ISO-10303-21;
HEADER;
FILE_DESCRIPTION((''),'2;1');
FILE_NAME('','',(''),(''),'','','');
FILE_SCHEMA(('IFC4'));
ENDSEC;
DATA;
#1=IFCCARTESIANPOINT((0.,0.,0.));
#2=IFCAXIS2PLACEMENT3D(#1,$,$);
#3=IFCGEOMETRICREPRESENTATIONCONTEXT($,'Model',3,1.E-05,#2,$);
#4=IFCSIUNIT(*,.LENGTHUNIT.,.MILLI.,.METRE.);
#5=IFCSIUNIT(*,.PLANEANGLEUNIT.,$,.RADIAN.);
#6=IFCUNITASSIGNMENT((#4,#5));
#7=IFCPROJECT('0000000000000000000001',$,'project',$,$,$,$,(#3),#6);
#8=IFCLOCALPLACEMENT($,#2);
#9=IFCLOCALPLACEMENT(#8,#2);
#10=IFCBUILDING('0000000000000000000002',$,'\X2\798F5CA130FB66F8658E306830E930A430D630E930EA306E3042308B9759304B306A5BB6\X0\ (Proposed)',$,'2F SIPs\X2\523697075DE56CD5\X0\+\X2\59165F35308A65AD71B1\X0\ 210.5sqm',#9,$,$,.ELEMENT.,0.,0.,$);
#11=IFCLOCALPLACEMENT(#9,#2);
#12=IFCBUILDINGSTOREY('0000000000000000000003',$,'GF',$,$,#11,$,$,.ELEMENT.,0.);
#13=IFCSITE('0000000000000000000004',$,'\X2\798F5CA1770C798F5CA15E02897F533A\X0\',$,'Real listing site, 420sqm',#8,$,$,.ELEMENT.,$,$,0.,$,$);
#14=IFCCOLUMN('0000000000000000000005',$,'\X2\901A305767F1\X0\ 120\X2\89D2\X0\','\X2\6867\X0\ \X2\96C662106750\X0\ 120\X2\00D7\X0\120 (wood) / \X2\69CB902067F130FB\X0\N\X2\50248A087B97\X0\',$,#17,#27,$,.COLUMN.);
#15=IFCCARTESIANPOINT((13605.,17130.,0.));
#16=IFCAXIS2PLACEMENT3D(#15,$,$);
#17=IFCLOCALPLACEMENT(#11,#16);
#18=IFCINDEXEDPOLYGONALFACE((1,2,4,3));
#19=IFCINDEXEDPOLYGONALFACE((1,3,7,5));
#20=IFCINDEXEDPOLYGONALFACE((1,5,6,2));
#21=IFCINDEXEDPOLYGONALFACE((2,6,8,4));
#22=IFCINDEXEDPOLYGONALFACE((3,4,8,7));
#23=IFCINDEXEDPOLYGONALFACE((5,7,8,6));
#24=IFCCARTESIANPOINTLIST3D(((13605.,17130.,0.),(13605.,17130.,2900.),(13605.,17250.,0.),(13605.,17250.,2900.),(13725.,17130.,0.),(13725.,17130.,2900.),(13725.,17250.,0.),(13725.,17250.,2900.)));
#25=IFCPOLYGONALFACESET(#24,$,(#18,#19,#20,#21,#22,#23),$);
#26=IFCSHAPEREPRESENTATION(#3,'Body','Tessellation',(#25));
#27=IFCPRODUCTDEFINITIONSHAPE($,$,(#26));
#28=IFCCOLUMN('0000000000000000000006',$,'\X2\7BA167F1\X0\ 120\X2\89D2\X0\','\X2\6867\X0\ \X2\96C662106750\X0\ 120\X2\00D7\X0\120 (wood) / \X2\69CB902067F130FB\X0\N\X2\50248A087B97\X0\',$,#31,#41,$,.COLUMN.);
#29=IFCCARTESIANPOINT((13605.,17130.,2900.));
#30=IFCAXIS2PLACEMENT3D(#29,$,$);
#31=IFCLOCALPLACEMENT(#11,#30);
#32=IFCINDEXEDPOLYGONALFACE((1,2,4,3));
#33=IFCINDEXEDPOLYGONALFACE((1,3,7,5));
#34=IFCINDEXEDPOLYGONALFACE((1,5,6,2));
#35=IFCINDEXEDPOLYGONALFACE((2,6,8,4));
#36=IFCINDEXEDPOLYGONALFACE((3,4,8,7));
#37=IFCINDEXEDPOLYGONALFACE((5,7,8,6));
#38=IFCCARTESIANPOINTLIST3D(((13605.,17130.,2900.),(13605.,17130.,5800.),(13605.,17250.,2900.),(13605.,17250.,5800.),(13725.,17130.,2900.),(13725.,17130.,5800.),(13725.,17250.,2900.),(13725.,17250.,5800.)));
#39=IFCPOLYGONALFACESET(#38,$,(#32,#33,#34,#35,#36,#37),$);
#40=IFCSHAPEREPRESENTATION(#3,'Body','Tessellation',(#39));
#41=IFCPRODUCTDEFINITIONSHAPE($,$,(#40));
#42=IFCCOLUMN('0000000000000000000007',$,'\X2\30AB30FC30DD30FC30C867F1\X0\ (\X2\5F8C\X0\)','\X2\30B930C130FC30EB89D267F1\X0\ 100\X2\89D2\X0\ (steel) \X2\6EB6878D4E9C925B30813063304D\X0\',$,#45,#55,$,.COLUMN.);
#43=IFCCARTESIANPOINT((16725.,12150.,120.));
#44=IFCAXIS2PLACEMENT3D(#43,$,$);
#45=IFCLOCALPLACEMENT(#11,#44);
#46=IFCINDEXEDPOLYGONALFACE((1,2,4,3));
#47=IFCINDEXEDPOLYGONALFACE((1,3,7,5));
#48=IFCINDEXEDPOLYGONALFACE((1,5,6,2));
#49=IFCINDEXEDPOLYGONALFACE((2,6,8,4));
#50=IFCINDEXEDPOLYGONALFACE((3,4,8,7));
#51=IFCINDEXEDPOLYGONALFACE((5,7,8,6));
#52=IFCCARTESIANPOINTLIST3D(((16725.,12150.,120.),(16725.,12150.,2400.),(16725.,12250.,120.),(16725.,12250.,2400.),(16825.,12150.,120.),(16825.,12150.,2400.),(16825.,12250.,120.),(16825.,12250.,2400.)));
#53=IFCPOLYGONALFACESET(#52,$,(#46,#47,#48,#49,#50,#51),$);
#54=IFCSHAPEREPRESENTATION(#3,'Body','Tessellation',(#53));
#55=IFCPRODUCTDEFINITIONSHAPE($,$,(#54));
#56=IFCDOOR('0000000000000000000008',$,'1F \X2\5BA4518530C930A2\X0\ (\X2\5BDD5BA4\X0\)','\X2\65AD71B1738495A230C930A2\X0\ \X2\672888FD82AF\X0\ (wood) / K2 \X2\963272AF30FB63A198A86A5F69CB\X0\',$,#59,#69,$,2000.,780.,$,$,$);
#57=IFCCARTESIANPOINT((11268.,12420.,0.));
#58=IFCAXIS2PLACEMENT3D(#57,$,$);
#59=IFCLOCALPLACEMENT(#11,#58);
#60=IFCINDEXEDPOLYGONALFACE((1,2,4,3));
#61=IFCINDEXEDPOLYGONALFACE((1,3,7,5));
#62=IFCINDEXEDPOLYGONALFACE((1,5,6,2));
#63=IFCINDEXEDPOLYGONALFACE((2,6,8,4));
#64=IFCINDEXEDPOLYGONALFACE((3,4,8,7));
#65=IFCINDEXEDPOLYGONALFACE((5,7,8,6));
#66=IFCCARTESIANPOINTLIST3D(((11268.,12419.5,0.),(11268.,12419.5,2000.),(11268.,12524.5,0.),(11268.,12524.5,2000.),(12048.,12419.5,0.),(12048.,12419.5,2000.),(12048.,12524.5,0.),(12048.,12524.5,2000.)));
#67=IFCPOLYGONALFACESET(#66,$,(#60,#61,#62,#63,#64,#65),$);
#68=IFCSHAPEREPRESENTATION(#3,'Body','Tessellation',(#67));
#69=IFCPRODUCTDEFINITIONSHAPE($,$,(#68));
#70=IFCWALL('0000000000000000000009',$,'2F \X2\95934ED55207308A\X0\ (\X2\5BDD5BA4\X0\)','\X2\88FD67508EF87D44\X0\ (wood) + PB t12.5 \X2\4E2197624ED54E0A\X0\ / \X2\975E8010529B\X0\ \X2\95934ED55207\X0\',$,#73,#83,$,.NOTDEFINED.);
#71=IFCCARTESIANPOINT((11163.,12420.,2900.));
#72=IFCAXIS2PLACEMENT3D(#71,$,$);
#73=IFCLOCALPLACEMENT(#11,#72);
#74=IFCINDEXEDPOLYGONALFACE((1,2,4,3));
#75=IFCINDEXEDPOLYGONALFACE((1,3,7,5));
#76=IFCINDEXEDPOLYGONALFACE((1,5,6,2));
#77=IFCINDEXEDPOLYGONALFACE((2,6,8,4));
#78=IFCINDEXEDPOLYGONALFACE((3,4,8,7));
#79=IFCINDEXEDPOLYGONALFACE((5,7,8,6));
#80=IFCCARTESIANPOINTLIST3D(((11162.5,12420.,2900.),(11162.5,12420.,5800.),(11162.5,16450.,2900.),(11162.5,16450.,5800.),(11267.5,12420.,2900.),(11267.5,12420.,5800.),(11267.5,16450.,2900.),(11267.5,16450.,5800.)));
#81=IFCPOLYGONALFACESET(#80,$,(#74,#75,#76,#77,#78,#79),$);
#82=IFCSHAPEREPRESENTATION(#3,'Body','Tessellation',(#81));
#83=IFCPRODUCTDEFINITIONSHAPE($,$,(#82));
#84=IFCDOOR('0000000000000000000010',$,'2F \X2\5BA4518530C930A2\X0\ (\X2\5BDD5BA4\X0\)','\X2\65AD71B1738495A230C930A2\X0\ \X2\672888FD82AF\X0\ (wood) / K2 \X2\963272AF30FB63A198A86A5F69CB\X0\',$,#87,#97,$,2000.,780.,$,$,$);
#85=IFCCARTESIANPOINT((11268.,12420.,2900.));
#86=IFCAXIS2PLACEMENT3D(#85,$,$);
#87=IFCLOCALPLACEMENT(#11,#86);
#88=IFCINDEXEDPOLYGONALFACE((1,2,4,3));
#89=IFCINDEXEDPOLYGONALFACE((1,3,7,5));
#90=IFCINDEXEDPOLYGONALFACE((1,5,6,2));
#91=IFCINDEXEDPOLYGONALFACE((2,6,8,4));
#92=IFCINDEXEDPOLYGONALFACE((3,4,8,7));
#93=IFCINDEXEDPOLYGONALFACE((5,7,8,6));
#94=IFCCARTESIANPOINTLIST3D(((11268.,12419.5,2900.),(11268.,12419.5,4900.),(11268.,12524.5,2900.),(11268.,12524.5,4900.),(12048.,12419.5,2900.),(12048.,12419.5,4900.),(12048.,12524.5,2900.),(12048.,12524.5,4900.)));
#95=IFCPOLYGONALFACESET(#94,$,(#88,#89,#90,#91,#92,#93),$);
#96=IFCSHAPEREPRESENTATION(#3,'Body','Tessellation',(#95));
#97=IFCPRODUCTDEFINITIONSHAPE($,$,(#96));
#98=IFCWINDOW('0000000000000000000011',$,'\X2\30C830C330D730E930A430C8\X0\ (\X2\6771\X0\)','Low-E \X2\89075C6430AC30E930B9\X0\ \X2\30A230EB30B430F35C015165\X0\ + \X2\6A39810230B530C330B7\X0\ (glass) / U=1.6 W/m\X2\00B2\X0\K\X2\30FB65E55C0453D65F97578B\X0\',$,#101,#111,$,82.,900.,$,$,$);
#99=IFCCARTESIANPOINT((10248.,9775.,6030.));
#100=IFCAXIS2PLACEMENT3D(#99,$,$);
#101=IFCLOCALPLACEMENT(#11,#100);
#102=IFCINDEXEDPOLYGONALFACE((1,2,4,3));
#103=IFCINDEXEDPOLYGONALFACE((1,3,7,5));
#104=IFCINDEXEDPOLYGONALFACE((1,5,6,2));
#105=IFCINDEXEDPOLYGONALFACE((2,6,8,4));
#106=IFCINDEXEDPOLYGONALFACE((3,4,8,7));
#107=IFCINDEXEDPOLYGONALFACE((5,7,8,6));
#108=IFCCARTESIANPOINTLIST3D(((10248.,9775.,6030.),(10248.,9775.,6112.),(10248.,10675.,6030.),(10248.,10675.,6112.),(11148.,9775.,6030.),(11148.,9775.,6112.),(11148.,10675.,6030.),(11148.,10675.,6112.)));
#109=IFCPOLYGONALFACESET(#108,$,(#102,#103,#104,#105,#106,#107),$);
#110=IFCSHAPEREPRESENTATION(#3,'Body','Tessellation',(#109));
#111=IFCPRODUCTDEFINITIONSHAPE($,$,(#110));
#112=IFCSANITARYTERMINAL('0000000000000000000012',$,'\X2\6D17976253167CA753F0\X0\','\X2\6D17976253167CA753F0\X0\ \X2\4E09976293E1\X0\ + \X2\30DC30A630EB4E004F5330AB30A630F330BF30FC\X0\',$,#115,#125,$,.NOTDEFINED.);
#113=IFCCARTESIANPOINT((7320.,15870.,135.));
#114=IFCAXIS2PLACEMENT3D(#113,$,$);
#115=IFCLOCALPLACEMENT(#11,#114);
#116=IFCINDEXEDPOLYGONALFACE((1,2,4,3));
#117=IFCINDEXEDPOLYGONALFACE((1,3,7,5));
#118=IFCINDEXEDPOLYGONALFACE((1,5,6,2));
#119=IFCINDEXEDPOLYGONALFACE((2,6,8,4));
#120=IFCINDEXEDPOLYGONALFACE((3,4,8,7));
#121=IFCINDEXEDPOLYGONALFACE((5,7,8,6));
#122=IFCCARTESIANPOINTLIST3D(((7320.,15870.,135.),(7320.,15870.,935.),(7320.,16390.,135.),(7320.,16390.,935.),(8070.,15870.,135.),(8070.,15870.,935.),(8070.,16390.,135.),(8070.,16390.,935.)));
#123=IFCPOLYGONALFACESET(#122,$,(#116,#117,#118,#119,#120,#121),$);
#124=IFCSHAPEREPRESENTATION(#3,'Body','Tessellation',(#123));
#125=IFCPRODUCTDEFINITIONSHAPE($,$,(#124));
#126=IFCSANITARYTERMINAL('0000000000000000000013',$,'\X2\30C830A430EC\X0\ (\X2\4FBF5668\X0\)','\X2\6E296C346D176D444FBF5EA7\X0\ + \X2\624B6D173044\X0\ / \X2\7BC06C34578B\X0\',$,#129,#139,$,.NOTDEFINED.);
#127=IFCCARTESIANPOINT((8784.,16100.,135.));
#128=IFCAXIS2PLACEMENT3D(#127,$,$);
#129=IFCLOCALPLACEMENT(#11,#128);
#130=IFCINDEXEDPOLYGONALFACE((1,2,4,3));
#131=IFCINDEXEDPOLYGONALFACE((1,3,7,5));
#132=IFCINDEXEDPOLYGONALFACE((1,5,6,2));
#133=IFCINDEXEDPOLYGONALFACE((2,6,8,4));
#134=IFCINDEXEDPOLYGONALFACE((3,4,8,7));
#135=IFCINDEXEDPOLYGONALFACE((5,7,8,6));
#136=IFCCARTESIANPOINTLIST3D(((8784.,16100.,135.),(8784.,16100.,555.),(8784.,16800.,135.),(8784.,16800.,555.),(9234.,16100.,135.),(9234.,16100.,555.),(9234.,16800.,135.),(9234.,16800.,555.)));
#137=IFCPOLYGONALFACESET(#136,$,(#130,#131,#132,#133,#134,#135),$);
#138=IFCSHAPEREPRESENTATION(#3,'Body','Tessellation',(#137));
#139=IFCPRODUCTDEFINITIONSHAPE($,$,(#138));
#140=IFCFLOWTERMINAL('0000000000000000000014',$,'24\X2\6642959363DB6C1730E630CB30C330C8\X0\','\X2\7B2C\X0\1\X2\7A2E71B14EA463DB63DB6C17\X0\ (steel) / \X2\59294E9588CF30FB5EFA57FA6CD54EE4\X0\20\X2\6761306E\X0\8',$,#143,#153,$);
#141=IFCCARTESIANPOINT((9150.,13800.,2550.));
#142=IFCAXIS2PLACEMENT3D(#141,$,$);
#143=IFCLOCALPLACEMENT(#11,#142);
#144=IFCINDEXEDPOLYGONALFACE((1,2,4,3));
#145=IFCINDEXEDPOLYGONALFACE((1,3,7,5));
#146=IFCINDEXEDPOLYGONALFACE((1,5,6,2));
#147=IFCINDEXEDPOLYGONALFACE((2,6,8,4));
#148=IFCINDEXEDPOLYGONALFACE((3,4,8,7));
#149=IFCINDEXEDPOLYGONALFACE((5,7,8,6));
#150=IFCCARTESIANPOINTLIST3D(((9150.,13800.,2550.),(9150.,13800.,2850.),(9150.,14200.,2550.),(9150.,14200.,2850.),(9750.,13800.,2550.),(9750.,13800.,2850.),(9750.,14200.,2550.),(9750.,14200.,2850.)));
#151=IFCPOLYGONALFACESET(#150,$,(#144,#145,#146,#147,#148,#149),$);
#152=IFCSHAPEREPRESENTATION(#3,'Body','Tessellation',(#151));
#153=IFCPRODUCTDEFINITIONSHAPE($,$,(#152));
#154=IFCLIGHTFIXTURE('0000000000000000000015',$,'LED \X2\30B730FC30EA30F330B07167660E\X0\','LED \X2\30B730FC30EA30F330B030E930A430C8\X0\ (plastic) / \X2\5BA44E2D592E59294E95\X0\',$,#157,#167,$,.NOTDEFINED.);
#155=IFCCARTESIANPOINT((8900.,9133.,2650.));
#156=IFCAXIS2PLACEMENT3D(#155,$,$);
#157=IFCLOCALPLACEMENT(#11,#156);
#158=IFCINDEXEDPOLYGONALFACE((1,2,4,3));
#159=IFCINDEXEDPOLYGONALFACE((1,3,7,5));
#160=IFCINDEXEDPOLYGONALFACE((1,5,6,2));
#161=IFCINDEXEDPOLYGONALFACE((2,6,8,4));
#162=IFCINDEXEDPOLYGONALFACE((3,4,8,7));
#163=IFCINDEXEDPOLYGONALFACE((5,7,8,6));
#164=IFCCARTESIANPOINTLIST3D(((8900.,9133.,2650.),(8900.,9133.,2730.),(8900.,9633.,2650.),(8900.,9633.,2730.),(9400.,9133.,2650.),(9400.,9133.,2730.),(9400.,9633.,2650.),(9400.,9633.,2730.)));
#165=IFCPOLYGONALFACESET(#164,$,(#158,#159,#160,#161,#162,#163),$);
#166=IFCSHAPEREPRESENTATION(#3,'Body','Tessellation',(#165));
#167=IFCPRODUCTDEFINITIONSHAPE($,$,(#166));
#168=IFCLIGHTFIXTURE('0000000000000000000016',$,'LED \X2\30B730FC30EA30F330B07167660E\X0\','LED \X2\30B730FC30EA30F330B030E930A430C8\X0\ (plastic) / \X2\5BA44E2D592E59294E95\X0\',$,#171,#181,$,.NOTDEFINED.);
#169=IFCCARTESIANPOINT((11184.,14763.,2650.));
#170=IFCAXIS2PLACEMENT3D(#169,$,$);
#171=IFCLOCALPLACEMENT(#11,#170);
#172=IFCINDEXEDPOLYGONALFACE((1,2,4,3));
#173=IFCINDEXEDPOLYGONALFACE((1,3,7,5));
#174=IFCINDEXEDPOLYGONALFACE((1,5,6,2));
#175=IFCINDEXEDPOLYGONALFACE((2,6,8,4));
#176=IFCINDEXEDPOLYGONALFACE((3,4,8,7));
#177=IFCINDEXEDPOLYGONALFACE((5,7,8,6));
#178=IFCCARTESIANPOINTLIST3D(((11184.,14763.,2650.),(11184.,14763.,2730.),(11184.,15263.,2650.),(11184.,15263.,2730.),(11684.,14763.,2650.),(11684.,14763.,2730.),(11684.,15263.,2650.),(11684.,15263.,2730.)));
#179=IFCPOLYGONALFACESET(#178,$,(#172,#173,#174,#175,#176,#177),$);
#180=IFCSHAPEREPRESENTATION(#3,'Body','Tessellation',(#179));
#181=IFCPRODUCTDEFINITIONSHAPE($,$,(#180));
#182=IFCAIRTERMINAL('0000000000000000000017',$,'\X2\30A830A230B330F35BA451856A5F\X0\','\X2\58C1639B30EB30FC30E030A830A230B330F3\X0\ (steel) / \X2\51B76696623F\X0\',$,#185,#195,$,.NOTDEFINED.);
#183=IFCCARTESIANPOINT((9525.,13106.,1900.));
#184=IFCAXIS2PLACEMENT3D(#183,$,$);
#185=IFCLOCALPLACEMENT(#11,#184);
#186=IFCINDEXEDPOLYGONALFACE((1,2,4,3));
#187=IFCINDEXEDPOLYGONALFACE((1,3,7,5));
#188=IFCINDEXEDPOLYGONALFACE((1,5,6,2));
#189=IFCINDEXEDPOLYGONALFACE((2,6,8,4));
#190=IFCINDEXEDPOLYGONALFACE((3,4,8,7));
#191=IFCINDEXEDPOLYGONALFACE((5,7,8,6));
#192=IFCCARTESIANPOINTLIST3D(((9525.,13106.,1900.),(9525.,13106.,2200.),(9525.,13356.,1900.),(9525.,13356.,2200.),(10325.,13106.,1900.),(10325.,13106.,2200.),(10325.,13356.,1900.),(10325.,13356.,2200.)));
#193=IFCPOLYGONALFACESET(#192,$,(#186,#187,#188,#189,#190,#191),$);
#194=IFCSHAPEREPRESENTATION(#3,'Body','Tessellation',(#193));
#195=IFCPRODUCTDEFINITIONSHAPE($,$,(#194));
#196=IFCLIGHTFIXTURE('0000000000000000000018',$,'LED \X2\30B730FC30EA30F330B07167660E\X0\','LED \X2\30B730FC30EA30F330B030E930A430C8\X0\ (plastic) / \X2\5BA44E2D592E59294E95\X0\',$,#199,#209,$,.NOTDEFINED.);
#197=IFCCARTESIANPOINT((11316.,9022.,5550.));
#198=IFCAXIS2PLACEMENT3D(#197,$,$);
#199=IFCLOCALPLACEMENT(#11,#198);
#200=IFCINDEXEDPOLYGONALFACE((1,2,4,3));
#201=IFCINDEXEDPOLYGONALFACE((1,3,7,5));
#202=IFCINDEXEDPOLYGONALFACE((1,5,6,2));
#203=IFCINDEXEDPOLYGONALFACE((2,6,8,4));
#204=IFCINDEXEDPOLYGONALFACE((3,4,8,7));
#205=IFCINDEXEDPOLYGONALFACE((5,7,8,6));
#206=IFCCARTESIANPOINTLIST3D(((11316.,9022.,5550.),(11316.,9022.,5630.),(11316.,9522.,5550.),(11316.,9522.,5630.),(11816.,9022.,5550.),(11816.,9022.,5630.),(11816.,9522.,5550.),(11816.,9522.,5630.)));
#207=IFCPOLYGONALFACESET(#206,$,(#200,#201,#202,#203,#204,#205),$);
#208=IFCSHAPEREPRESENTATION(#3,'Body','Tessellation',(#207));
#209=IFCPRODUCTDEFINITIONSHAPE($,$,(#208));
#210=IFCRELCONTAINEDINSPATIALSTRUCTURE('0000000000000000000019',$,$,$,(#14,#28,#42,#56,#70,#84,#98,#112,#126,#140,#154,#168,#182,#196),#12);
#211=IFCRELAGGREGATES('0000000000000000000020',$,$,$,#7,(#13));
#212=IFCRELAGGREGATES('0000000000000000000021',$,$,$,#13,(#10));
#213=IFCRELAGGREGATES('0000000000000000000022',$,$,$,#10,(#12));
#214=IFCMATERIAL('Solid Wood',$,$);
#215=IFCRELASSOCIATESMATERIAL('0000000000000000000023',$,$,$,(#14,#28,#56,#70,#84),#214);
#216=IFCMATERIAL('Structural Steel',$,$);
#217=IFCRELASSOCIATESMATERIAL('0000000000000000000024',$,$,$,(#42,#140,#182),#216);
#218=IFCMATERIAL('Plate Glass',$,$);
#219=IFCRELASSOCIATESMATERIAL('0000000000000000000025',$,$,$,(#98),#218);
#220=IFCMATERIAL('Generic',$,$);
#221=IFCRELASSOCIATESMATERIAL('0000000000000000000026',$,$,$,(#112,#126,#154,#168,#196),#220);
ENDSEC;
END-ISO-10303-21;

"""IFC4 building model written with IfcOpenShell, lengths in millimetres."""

from ifc_helpers import new_model, si_unit, frame, frame_2d, origin, place, context, project, spatial, rectangle, extrude, material, element, save


model = new_model("IFC4")

# Units and contexts
model_context = context("Model", 3, precision=1e-05, world=origin())
ifc_project = project(units=[si_unit("LENGTHUNIT", "METRE", prefix="MILLI"), si_unit("PLANEANGLEUNIT", "RADIAN")], contexts=[model_context])

# Site, building, storey
site_placement = place(None, origin())
site = spatial("IfcSite", under=ifc_project, at=site_placement, Name="福岡県福岡市西区", ObjectType="Real listing site, 420sqm", CompositionType="ELEMENT", RefElevation=0.0)
building_placement = place(site_placement, origin())
building = spatial("IfcBuilding", under=site, at=building_placement, Name="福岡・書斎とライブラリのある静かな家 (Proposed)", ObjectType="2F SIPs制震工法+外張り断熱 210.5sqm", CompositionType="ELEMENT", ElevationOfRefHeight=0.0, ElevationOfTerrain=0.0)
storey_placement = place(building_placement, origin())
storey = spatial("IfcBuildingStorey", under=building, at=storey_placement, Name="GF", CompositionType="ELEMENT", Elevation=0.0)

# Columns
ifc_material_1 = material(Name="Solid Wood")
column_1_placement = place(storey_placement, frame((13605.0, 17130.0, 0.0)))
element("IfcColumn", 1, at=column_1_placement, inside=storey, material=ifc_material_1, Name="通し柱 120角", Description="桧 集成材 120×120 (wood) / 構造柱・N値計算", PredefinedType="COLUMN", context=model_context, shape_type="SweptSolid", body=[
    extrude(rectangle(XDim=120.0, YDim=120.0, at=frame_2d((60.0, 60.0))), frame((13605.0, 17130.0, 0.0)), (0.0, 0.0, 1.0), 2900.0),
])
column_2_placement = place(storey_placement, frame((13605.0, 17130.0, 2900.0)))
element("IfcColumn", 2, at=column_2_placement, inside=storey, material=ifc_material_1, Name="管柱 120角", Description="桧 集成材 120×120 (wood) / 構造柱・N値計算", PredefinedType="COLUMN", context=model_context, shape_type="SweptSolid", body=[
    extrude(rectangle(XDim=120.0, YDim=120.0, at=frame_2d((60.0, 60.0))), frame((13605.0, 17130.0, 2900.0)), (0.0, 0.0, 1.0), 2900.0),
])
ifc_material_2 = material(Name="Structural Steel")
column_3_placement = place(storey_placement, frame((16725.0, 12150.0, 120.0)))
element("IfcColumn", 3, at=column_3_placement, inside=storey, material=ifc_material_2, Name="カーポート柱 (後)", Description="スチール角柱 100角 (steel) 溶融亜鉛めっき", PredefinedType="COLUMN", context=model_context, shape_type="SweptSolid", body=[
    extrude(rectangle(XDim=100.0, YDim=100.0, at=frame_2d((50.0, 50.0))), frame((16725.0, 12150.0, 120.0)), (0.0, 0.0, 1.0), 2280.0),
])

# Door
door_1_placement = place(storey_placement, frame((11268.0, 12420.0, 0.0)))
element("IfcDoor", 4, at=door_1_placement, inside=storey, material=ifc_material_1, Name="1F 室内ドア (寝室)", Description="断熱玄関ドア 木製芯 (wood) / K2 防犯・採風機構", OverallHeight=2000.0, OverallWidth=780.0, context=model_context, shape_type="SweptSolid", body=[
    extrude(rectangle(XDim=780.0, YDim=105.0, at=frame_2d((390.0, 52.0))), frame((11268.0, 12420.0, 0.0)), (0.0, 0.0, 1.0), 2000.0),
])

# Wall
wall_1_placement = place(storey_placement, frame((11163.0, 12420.0, 2900.0)))
element("IfcWall", 5, at=wall_1_placement, inside=storey, material=ifc_material_1, Name="2F 間仕切り (寝室)", Description="製材軸組 (wood) + PB t12.5 両面仕上 / 非耐力 間仕切", PredefinedType="NOTDEFINED", context=model_context, shape_type="SweptSolid", body=[
    extrude(rectangle(XDim=105.0, YDim=4030.0, at=frame_2d((52.0, 2015.0))), frame((11163.0, 12420.0, 2900.0)), (0.0, 0.0, 1.0), 2900.0),
])

# Door
door_2_placement = place(storey_placement, frame((11268.0, 12420.0, 2900.0)))
element("IfcDoor", 6, at=door_2_placement, inside=storey, material=ifc_material_1, Name="2F 室内ドア (寝室)", Description="断熱玄関ドア 木製芯 (wood) / K2 防犯・採風機構", OverallHeight=2000.0, OverallWidth=780.0, context=model_context, shape_type="SweptSolid", body=[
    extrude(rectangle(XDim=780.0, YDim=105.0, at=frame_2d((390.0, 52.0))), frame((11268.0, 12420.0, 2900.0)), (0.0, 0.0, 1.0), 2000.0),
])

# Window
ifc_material_3 = material(Name="Plate Glass")
window_placement = place(storey_placement, frame((10248.0, 9775.0, 6030.0)))
element("IfcWindow", 7, at=window_placement, inside=storey, material=ifc_material_3, Name="トップライト (東)", Description="Low-E 複層ガラス アルゴン封入 + 樹脂サッシ (glass) / U=1.6 W/m²K・日射取得型", OverallHeight=82.0, OverallWidth=900.0, context=model_context, shape_type="SweptSolid", body=[
    extrude(rectangle(XDim=900.0, YDim=900.0, at=frame_2d((450.0, 450.0))), frame((10248.0, 9775.0, 6030.0)), (0.0, 0.0, 1.0), 82.0),
])

# Sanitary terminals
ifc_material_4 = material(Name="Generic")
sanitary_terminal_1_placement = place(storey_placement, frame((7320.0, 15870.0, 135.0)))
element("IfcSanitaryTerminal", 8, at=sanitary_terminal_1_placement, inside=storey, material=ifc_material_4, Name="洗面化粧台", Description="洗面化粧台 三面鏡 + ボウル一体カウンター", PredefinedType="NOTDEFINED", context=model_context, shape_type="SweptSolid", body=[
    extrude(rectangle(XDim=750.0, YDim=520.0, at=frame_2d((375.0, 260.0))), frame((7320.0, 15870.0, 135.0)), (0.0, 0.0, 1.0), 800.0),
])
sanitary_terminal_2_placement = place(storey_placement, frame((8784.0, 16100.0, 135.0)))
element("IfcSanitaryTerminal", 9, at=sanitary_terminal_2_placement, inside=storey, material=ifc_material_4, Name="トイレ (便器)", Description="温水洗浄便座 + 手洗い / 節水型", PredefinedType="NOTDEFINED", context=model_context, shape_type="SweptSolid", body=[
    extrude(rectangle(XDim=450.0, YDim=700.0, at=frame_2d((225.0, 350.0))), frame((8784.0, 16100.0, 135.0)), (0.0, 0.0, 1.0), 420.0),
])

# Flow terminal
flow_terminal_placement = place(storey_placement, frame((9150.0, 13800.0, 2550.0)))
element("IfcFlowTerminal", 10, at=flow_terminal_placement, inside=storey, material=ifc_material_2, Name="24時間換気ユニット", Description="第1種熱交換換気 (steel) / 天井裏・建基法令20条の8", context=model_context, shape_type="SweptSolid", body=[
    extrude(rectangle(XDim=600.0, YDim=400.0, at=frame_2d((300.0, 200.0))), frame((9150.0, 13800.0, 2550.0)), (0.0, 0.0, 1.0), 300.0),
])

# Light fixtures
light_fixture_1_placement = place(storey_placement, frame((8900.0, 9133.0, 2650.0)))
element("IfcLightFixture", 11, at=light_fixture_1_placement, inside=storey, material=ifc_material_4, Name="LED シーリング照明", Description="LED シーリングライト (plastic) / 室中央天井", PredefinedType="NOTDEFINED", context=model_context, shape_type="SweptSolid", body=[
    extrude(rectangle(XDim=500.0, YDim=500.0, at=frame_2d((250.0, 250.0))), frame((8900.0, 9133.0, 2650.0)), (0.0, 0.0, 1.0), 80.0),
])
light_fixture_2_placement = place(storey_placement, frame((11184.0, 14763.0, 2650.0)))
element("IfcLightFixture", 12, at=light_fixture_2_placement, inside=storey, material=ifc_material_4, Name="LED シーリング照明", Description="LED シーリングライト (plastic) / 室中央天井", PredefinedType="NOTDEFINED", context=model_context, shape_type="SweptSolid", body=[
    extrude(rectangle(XDim=500.0, YDim=500.0, at=frame_2d((250.0, 250.0))), frame((11184.0, 14763.0, 2650.0)), (0.0, 0.0, 1.0), 80.0),
])

# Air terminal
air_terminal_placement = place(storey_placement, frame((9525.0, 13106.0, 1900.0)))
element("IfcAirTerminal", 13, at=air_terminal_placement, inside=storey, material=ifc_material_2, Name="エアコン室内機", Description="壁掛ルームエアコン (steel) / 冷暖房", PredefinedType="NOTDEFINED", context=model_context, shape_type="SweptSolid", body=[
    extrude(rectangle(XDim=800.0, YDim=250.0, at=frame_2d((400.0, 125.0))), frame((9525.0, 13106.0, 1900.0)), (0.0, 0.0, 1.0), 300.0),
])

# Light fixture
light_fixture_3_placement = place(storey_placement, frame((11316.0, 9022.0, 5550.0)))
element("IfcLightFixture", 14, at=light_fixture_3_placement, inside=storey, material=ifc_material_4, Name="LED シーリング照明", Description="LED シーリングライト (plastic) / 室中央天井", PredefinedType="NOTDEFINED", context=model_context, shape_type="SweptSolid", body=[
    extrude(rectangle(XDim=500.0, YDim=500.0, at=frame_2d((250.0, 250.0))), frame((11316.0, 9022.0, 5550.0)), (0.0, 0.0, 1.0), 80.0),
])

save(model, "model.ifc")
